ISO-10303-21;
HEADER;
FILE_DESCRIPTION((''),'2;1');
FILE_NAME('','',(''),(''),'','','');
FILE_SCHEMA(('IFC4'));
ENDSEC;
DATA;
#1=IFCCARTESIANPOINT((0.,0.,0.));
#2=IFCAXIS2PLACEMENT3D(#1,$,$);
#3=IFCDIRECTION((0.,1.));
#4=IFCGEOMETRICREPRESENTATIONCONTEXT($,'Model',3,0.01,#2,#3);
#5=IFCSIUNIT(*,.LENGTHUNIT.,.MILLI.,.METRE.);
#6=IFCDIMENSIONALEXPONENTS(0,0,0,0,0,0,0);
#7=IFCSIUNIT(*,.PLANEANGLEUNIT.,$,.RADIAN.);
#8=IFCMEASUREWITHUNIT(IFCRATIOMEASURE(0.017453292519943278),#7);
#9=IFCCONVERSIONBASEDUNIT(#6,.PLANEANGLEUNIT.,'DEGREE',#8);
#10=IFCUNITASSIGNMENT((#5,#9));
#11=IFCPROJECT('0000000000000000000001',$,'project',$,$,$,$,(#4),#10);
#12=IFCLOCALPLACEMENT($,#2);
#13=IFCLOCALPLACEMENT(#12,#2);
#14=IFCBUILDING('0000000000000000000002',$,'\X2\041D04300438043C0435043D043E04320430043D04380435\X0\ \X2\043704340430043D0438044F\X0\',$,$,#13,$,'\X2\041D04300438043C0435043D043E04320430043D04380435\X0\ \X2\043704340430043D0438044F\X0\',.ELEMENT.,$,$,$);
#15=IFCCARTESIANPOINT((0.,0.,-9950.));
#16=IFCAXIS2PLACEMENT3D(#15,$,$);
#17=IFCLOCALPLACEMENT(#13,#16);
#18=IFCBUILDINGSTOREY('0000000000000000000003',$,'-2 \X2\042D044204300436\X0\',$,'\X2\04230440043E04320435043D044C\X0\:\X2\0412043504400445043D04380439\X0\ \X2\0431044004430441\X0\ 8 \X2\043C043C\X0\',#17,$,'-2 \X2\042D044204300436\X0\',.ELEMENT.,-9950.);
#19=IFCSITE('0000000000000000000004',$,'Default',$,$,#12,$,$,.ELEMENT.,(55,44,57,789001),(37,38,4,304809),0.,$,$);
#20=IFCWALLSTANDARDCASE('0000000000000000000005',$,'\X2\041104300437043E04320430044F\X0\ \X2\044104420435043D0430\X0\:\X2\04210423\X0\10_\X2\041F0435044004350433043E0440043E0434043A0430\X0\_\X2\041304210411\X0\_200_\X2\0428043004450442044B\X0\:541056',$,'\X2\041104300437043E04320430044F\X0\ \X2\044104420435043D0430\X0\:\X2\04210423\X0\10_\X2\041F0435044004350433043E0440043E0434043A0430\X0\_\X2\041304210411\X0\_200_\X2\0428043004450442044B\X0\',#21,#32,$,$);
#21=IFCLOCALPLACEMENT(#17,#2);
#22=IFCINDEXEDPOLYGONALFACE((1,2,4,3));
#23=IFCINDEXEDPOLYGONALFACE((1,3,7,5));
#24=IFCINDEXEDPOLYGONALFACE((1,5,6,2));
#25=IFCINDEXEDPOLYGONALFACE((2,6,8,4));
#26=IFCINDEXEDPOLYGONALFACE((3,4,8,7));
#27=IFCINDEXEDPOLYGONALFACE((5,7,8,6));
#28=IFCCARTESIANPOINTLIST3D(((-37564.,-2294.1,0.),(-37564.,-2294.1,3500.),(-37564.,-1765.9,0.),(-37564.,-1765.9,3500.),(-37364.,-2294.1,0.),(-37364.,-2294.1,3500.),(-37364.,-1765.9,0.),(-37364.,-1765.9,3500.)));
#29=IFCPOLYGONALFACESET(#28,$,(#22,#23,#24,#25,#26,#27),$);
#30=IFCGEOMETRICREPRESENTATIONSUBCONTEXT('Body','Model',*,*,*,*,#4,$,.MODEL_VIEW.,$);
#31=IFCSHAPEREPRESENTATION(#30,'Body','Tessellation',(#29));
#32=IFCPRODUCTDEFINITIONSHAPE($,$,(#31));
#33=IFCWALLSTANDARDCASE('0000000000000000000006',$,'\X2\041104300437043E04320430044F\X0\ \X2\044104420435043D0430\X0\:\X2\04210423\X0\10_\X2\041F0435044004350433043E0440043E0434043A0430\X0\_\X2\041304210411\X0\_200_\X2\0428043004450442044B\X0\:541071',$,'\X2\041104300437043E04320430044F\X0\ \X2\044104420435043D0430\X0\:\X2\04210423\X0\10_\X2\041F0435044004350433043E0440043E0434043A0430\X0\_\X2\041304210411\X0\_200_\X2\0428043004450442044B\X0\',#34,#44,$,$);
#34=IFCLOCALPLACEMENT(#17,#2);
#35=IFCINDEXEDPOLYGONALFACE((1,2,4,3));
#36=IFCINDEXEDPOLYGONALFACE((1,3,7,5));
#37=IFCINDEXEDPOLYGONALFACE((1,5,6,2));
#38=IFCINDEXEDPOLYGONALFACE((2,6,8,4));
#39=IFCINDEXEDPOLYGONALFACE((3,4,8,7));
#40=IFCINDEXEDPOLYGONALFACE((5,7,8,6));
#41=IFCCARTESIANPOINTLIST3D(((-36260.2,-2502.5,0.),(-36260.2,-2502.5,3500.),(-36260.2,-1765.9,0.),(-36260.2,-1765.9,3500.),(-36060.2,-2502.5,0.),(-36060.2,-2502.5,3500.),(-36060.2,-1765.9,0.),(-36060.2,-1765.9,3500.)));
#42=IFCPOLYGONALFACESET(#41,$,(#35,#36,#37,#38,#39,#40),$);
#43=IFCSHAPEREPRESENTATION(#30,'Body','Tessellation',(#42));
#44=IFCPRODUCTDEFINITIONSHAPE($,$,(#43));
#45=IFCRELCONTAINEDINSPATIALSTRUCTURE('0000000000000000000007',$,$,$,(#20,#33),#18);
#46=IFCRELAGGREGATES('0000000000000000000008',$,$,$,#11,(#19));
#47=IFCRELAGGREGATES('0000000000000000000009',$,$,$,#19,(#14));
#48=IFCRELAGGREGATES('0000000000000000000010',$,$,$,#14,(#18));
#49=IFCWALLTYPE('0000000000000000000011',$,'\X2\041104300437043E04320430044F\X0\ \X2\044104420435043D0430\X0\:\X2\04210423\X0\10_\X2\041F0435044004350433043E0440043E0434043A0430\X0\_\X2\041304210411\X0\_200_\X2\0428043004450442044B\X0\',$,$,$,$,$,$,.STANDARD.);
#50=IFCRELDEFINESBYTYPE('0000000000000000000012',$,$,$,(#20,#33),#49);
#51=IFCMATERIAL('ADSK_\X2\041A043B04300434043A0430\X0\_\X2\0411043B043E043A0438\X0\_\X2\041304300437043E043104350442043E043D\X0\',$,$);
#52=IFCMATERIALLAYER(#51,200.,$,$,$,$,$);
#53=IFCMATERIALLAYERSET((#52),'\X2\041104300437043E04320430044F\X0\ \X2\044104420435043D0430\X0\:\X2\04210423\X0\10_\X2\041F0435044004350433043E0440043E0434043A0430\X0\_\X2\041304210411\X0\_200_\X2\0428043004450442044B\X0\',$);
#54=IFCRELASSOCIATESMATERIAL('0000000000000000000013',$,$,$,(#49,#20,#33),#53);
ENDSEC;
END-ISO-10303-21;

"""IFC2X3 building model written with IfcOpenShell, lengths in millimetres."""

from ifc_helpers import new_model, entity, si_unit, converted_unit, direction, frame, frame_2d, origin, place, context, subcontext, project, spatial, rectangle, extrude, material, layer, layer_set, layer_usage, type_object, element, save


model = new_model("IFC2X3")

# Units and contexts
model_context = context("Model", 3, precision=0.01, world=origin(), true_north=direction((0.0, 1.0)))
body_context = subcontext(model_context, "Body", "Model", "MODEL_VIEW")
ifc_project = project(units=[si_unit("LENGTHUNIT", "METRE", prefix="MILLI"), converted_unit("PLANEANGLEUNIT", "DEGREE", entity("IfcRatioMeasure", 0.017453292519943278), si_unit("PLANEANGLEUNIT", "RADIAN"), dimensions=[0, 0, 0, 0, 0, 0, 0])], contexts=[model_context])

# Site, building, storey
site_placement = place(None, origin())
site = spatial("IfcSite", under=ifc_project, at=site_placement, Name="Default", CompositionType="ELEMENT", RefLatitude=(55, 44, 57, 789001), RefLongitude=(37, 38, 4, 304809), RefElevation=0.0)
building_placement = place(site_placement, origin())
building = spatial("IfcBuilding", under=site, at=building_placement, Name="Наименование здания", LongName="Наименование здания", CompositionType="ELEMENT")
storey_placement = place(building_placement, frame((0.0, 0.0, -9950.0)))
storey = spatial("IfcBuildingStorey", under=building, at=storey_placement, Name="-2 Этаж", ObjectType="Уровень:Верхний брус 8 мм", LongName="-2 Этаж", CompositionType="ELEMENT", Elevation=-9950.0)

# Walls
ifc_material_1 = material(Name="ADSK_Кладка_Блоки_Газобетон")
ifc_layer_1 = layer(ifc_material_1, 200.0)
ifc_layer_set_1 = layer_set([ifc_layer_1], Name="Базовая стена:СУ10_Перегородка_ГСБ_200_Шахты")
ifc_layer_usage_1 = layer_usage(ifc_layer_set_1, "AXIS2", "NEGATIVE", 100.0)
wall_type_1 = type_object("IfcWallType", Name="Базовая стена:СУ10_Перегородка_ГСБ_200_Шахты", PredefinedType="STANDARD", material=ifc_layer_set_1)
wall_1_placement = place(storey_placement, frame((-37464.0, -1765.9, 0.0), z_axis=(0.0, 0.0, 1.0), x_axis=(0.0, -1.0, 0.0)))
element("IfcWallStandardCase", 1, at=wall_1_placement, inside=storey, type_object=wall_type_1, material=ifc_layer_usage_1, Name="Базовая стена:СУ10_Перегородка_ГСБ_200_Шахты:541056", ObjectType="Базовая стена:СУ10_Перегородка_ГСБ_200_Шахты", context=body_context, shape_type="SweptSolid", body=[
    extrude(rectangle(XDim=528.2, YDim=200.0, at=frame_2d((264.1, 0.0), x_axis=(-1.0, 0.0))), origin(), (0.0, 0.0, 1.0), 3500.0),
])
wall_2_placement = place(storey_placement, frame((-36160.2, -1765.9, 0.0), z_axis=(0.0, 0.0, 1.0), x_axis=(0.0, -1.0, 0.0)))
element("IfcWallStandardCase", 2, at=wall_2_placement, inside=storey, type_object=wall_type_1, material=ifc_layer_usage_1, Name="Базовая стена:СУ10_Перегородка_ГСБ_200_Шахты:541071", ObjectType="Базовая стена:СУ10_Перегородка_ГСБ_200_Шахты", context=body_context, shape_type="SweptSolid", body=[
    extrude(rectangle(XDim=736.6, YDim=200.0, at=frame_2d((368.3, 0.0), x_axis=(-1.0, 0.0))), origin(), (0.0, 0.0, 1.0), 3500.0),
])

save(model, "model.ifc")
